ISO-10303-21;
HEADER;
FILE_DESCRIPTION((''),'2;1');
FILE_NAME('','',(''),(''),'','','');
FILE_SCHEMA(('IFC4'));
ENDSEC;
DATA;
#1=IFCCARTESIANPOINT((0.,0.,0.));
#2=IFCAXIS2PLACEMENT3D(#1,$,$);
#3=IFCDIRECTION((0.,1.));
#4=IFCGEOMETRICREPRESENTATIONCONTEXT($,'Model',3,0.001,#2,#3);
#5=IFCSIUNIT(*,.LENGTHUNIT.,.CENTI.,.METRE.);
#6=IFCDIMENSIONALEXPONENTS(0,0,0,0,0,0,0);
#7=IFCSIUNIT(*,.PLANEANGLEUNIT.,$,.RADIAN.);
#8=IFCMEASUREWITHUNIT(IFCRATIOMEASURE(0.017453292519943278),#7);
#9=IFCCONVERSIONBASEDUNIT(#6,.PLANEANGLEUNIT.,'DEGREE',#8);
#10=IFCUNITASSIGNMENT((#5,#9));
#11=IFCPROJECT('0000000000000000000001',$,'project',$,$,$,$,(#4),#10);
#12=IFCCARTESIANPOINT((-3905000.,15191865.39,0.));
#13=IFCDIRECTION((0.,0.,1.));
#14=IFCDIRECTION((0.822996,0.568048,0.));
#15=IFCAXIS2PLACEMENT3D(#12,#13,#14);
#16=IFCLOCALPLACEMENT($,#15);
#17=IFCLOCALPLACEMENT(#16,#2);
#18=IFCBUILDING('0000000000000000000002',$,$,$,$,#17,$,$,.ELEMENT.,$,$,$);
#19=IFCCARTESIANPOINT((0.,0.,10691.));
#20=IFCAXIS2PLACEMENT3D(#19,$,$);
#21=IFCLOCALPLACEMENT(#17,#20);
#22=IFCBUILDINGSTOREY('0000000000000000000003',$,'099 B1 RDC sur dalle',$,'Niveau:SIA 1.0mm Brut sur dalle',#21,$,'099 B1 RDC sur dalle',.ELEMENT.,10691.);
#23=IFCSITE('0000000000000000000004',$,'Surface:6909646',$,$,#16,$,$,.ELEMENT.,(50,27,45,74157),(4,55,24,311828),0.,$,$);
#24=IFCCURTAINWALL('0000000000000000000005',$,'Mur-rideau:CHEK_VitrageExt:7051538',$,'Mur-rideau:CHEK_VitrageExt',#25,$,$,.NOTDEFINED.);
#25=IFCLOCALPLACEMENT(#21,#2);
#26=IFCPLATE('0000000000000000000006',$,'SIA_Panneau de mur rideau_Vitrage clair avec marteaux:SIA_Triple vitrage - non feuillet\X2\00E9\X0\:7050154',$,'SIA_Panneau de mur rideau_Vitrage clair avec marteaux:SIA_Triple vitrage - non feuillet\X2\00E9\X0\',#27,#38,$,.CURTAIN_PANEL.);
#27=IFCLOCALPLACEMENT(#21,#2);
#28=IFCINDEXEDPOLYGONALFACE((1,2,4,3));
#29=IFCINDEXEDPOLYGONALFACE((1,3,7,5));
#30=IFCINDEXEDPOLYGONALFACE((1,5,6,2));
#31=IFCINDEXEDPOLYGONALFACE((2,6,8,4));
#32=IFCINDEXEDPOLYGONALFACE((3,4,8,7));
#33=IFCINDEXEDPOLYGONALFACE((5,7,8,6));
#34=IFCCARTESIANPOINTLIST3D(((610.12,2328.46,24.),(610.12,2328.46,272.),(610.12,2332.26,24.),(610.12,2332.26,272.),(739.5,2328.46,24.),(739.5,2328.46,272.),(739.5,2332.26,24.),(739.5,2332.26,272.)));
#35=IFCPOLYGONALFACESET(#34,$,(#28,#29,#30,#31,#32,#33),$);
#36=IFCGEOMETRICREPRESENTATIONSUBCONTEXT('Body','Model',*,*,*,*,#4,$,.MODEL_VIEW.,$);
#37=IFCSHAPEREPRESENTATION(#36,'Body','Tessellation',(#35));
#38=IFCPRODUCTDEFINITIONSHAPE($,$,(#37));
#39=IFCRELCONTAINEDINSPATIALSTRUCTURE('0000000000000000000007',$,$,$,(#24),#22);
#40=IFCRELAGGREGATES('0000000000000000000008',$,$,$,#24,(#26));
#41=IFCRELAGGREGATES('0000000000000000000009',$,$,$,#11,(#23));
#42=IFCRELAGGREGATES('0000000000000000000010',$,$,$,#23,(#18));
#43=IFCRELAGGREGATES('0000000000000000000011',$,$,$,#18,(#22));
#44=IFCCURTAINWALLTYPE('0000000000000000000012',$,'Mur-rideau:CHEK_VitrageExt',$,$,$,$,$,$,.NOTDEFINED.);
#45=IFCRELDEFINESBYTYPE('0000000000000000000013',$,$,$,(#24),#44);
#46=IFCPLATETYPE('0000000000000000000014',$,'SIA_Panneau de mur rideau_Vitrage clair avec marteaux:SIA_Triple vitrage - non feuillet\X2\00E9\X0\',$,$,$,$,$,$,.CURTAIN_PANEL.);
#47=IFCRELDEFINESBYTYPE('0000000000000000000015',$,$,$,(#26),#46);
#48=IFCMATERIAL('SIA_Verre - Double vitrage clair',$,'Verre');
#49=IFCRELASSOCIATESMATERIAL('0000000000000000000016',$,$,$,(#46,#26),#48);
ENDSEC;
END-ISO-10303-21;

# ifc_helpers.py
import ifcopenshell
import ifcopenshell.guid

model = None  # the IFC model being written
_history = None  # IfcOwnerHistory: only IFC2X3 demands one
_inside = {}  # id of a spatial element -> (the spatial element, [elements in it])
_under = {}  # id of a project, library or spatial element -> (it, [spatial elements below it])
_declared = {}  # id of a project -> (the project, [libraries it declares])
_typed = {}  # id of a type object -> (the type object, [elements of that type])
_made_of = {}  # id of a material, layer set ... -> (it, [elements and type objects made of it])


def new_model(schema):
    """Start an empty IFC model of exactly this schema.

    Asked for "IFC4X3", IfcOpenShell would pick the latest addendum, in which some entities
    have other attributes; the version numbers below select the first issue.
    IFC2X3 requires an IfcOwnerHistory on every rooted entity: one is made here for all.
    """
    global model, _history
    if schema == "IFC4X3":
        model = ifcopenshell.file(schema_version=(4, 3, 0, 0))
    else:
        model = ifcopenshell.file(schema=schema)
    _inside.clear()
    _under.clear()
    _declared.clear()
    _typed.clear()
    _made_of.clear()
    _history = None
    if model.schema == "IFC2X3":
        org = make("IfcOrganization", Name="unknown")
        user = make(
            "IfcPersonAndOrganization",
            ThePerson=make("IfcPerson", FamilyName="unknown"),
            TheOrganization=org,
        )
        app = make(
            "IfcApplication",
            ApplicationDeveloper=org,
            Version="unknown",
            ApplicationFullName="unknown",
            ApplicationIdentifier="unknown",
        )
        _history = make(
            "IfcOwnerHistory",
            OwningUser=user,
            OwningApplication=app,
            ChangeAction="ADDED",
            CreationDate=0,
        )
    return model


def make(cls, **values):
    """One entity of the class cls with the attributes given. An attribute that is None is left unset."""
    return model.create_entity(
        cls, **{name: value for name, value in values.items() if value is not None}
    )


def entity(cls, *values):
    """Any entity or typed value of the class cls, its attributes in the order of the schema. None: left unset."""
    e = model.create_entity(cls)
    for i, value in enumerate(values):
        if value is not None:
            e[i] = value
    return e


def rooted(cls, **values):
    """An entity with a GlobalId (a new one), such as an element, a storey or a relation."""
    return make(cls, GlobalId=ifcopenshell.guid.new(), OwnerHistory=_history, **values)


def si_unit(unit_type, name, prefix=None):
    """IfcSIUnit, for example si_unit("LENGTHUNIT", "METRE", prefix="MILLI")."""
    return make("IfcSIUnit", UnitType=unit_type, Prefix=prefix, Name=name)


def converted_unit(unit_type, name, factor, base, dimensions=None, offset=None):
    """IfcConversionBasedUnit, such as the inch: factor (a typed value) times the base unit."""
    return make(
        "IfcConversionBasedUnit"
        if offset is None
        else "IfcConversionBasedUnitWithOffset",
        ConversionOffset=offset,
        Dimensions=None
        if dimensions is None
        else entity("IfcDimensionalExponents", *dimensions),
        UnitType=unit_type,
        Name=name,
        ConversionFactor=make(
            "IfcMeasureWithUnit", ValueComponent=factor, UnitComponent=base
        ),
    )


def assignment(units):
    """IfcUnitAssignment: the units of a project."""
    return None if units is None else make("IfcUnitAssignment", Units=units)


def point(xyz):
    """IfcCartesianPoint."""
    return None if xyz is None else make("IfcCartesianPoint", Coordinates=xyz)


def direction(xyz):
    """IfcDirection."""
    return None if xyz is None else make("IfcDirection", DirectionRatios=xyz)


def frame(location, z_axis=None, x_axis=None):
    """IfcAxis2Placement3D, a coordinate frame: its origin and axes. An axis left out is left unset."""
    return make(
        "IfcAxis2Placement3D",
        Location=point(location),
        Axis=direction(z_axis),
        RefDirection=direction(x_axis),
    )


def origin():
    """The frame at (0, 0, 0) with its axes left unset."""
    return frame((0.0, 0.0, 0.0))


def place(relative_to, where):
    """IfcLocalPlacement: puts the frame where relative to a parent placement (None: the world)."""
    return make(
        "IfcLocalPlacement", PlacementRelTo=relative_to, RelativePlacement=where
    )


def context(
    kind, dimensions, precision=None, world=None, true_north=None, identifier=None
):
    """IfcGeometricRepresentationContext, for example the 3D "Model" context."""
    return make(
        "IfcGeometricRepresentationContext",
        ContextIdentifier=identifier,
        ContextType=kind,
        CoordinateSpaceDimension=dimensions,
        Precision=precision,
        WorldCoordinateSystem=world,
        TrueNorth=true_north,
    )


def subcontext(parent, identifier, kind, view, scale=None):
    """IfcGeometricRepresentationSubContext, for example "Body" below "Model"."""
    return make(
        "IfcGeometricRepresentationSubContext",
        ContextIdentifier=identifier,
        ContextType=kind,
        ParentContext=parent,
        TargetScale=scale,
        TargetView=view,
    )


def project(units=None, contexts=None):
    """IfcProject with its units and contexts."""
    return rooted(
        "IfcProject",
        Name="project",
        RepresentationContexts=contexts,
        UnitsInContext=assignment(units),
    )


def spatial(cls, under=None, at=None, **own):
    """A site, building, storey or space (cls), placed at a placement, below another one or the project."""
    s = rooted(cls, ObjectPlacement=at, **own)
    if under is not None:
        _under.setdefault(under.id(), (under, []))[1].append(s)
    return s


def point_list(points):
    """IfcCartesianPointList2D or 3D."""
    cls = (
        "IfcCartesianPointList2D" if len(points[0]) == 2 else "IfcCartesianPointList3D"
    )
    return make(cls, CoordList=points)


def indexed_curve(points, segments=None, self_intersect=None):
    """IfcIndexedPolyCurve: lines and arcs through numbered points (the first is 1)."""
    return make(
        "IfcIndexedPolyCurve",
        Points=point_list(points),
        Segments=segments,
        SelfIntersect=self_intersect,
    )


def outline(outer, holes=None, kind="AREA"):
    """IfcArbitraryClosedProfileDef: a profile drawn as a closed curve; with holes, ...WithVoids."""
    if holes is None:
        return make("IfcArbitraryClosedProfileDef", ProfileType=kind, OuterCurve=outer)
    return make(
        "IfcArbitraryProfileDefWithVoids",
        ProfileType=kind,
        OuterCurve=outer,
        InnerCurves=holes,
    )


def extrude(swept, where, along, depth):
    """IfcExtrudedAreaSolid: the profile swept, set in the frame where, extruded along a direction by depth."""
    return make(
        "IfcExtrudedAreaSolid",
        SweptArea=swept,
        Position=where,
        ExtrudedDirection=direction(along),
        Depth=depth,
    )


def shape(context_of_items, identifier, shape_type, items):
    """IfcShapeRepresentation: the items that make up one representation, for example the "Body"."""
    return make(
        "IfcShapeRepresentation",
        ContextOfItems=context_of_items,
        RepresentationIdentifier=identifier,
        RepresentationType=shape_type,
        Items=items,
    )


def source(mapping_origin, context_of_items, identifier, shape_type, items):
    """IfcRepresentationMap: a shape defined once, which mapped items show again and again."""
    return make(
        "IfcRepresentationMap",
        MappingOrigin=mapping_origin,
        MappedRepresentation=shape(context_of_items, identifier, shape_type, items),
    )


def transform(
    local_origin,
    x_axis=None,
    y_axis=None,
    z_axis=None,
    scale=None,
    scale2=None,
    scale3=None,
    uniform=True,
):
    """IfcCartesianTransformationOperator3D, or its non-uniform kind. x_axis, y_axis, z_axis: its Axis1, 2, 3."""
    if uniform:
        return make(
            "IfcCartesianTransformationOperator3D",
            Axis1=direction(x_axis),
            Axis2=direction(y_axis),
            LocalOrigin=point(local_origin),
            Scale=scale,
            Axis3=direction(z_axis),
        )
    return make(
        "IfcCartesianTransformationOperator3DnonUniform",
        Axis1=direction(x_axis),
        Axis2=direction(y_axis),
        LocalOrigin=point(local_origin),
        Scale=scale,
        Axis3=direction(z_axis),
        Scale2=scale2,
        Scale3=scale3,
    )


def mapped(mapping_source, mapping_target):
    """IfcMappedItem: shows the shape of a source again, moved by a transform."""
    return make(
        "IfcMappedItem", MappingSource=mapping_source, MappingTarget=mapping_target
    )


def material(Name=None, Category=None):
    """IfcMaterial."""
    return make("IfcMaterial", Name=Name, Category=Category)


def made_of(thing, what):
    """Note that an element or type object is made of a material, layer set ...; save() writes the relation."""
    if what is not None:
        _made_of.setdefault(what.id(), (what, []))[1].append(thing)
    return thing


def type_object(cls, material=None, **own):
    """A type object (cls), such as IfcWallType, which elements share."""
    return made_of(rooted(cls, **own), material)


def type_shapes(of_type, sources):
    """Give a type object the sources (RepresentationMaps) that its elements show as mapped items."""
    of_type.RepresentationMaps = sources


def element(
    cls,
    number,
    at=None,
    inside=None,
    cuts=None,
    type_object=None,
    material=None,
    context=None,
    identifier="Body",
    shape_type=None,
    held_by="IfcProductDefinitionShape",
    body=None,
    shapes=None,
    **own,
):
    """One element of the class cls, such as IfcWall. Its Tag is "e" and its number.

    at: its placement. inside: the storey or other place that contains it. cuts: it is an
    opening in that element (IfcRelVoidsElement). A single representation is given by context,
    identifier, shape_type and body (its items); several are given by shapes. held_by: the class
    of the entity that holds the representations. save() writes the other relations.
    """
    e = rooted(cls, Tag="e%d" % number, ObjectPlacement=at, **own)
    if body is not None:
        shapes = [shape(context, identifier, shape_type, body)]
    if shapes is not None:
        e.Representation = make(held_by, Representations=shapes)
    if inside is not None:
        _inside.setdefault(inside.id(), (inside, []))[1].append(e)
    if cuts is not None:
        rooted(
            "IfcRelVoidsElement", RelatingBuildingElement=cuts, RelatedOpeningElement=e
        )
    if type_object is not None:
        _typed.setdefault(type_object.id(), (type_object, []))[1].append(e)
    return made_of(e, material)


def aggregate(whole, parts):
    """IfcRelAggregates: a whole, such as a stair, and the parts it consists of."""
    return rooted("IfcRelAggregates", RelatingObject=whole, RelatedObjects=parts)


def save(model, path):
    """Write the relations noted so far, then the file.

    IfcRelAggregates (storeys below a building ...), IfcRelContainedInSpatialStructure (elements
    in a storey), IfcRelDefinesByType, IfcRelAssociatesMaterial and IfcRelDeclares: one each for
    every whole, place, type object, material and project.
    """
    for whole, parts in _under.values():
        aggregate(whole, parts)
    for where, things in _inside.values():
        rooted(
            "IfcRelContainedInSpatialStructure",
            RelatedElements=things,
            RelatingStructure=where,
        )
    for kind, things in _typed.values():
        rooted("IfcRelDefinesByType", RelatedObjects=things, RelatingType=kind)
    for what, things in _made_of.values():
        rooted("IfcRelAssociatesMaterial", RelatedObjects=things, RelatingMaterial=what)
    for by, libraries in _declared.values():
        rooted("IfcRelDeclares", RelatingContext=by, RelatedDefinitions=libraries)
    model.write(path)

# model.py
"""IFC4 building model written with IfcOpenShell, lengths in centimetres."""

from ifc_helpers import new_model, entity, si_unit, converted_unit, direction, frame, origin, place, context, subcontext, project, spatial, indexed_curve, outline, extrude, source, transform, mapped, material, type_object, type_shapes, element, aggregate, save


model = new_model("IFC4")

# Units and contexts
model_context = context("Model", 3, precision=0.001, world=origin(), true_north=direction((0.0, 1.0)))
body_context = subcontext(model_context, "Body", "Model", "MODEL_VIEW")
ifc_project = project(units=[si_unit("LENGTHUNIT", "METRE", prefix="CENTI"), converted_unit("PLANEANGLEUNIT", "DEGREE", entity("IfcRatioMeasure", 0.017453292519943278), si_unit("PLANEANGLEUNIT", "RADIAN"), dimensions=[0, 0, 0, 0, 0, 0, 0])], contexts=[model_context])

# Site, building, storey
site_placement = place(None, frame((-3905000.0, 15191865.39, 0.0), z_axis=(0.0, 0.0, 1.0), x_axis=(0.822996, 0.568048, 0.0)))
site = spatial("IfcSite", under=ifc_project, at=site_placement, Name="Surface:6909646", CompositionType="ELEMENT", RefLatitude=(50, 27, 45, 74157), RefLongitude=(4, 55, 24, 311828), RefElevation=0.0)
building_placement = place(site_placement, origin())
building = spatial("IfcBuilding", under=site, at=building_placement, CompositionType="ELEMENT")
storey_placement = place(building_placement, frame((0.0, 0.0, 10691.0)))
storey = spatial("IfcBuildingStorey", under=building, at=storey_placement, Name="099 B1 RDC sur dalle", ObjectType="Niveau:SIA 1.0mm Brut sur dalle", LongName="099 B1 RDC sur dalle", CompositionType="ELEMENT", Elevation=10691.0)

# Shared definitions
curtain_wall_type = type_object("IfcCurtainWallType", Name="Mur-rideau:CHEK_VitrageExt", PredefinedType="NOTDEFINED")

# Curtain wall
curtain_wall_1_placement = place(storey_placement, frame((0.0, 0.0, -10691.0)))
curtain_wall_1 = element("IfcCurtainWall", 1, at=curtain_wall_1_placement, inside=storey, type_object=curtain_wall_type, Name="Mur-rideau:CHEK_VitrageExt:7051538", ObjectType="Mur-rideau:CHEK_VitrageExt", PredefinedType="NOTDEFINED")

# Plate
ifc_material_1 = material(Name="SIA_Verre - Double vitrage clair", Category="Verre")
plate_type_1 = type_object("IfcPlateType", Name="SIA_Panneau de mur rideau_Vitrage clair avec marteaux:SIA_Triple vitrage - non feuilleté", PredefinedType="CURTAIN_PANEL", material=ifc_material_1)
shared_shape_1 = source(origin(), body_context, "Body", "SweptSolid", [
    extrude(outline(indexed_curve([(-1.9, -64.69), (1.9, -64.69), (1.9, 64.69), (-1.9, 64.69), (-1.9, -64.69)], self_intersect=False)), frame((0.0, -1.9, 0.0), z_axis=(0.0, 0.0, 1.0), x_axis=(0.0, 1.0, 0.0)), (0.0, 0.0, 1.0), 248.0),
])
type_shapes(plate_type_1, [shared_shape_1])
plate_1_placement = place(curtain_wall_1_placement, frame((674.81, 2332.26, 10715.0)))
plate_1 = element("IfcPlate", 2, at=plate_1_placement, type_object=plate_type_1, material=ifc_material_1, Name="SIA_Panneau de mur rideau_Vitrage clair avec marteaux:SIA_Triple vitrage - non feuilleté:7050154", ObjectType="SIA_Panneau de mur rideau_Vitrage clair avec marteaux:SIA_Triple vitrage - non feuilleté", PredefinedType="CURTAIN_PANEL", context=body_context, shape_type="MappedRepresentation", body=[
    mapped(shared_shape_1, transform((0.0, 0.0, 0.0), scale=1.0)),
])
aggregate(curtain_wall_1, [plate_1])

save(model, "model.ifc")
